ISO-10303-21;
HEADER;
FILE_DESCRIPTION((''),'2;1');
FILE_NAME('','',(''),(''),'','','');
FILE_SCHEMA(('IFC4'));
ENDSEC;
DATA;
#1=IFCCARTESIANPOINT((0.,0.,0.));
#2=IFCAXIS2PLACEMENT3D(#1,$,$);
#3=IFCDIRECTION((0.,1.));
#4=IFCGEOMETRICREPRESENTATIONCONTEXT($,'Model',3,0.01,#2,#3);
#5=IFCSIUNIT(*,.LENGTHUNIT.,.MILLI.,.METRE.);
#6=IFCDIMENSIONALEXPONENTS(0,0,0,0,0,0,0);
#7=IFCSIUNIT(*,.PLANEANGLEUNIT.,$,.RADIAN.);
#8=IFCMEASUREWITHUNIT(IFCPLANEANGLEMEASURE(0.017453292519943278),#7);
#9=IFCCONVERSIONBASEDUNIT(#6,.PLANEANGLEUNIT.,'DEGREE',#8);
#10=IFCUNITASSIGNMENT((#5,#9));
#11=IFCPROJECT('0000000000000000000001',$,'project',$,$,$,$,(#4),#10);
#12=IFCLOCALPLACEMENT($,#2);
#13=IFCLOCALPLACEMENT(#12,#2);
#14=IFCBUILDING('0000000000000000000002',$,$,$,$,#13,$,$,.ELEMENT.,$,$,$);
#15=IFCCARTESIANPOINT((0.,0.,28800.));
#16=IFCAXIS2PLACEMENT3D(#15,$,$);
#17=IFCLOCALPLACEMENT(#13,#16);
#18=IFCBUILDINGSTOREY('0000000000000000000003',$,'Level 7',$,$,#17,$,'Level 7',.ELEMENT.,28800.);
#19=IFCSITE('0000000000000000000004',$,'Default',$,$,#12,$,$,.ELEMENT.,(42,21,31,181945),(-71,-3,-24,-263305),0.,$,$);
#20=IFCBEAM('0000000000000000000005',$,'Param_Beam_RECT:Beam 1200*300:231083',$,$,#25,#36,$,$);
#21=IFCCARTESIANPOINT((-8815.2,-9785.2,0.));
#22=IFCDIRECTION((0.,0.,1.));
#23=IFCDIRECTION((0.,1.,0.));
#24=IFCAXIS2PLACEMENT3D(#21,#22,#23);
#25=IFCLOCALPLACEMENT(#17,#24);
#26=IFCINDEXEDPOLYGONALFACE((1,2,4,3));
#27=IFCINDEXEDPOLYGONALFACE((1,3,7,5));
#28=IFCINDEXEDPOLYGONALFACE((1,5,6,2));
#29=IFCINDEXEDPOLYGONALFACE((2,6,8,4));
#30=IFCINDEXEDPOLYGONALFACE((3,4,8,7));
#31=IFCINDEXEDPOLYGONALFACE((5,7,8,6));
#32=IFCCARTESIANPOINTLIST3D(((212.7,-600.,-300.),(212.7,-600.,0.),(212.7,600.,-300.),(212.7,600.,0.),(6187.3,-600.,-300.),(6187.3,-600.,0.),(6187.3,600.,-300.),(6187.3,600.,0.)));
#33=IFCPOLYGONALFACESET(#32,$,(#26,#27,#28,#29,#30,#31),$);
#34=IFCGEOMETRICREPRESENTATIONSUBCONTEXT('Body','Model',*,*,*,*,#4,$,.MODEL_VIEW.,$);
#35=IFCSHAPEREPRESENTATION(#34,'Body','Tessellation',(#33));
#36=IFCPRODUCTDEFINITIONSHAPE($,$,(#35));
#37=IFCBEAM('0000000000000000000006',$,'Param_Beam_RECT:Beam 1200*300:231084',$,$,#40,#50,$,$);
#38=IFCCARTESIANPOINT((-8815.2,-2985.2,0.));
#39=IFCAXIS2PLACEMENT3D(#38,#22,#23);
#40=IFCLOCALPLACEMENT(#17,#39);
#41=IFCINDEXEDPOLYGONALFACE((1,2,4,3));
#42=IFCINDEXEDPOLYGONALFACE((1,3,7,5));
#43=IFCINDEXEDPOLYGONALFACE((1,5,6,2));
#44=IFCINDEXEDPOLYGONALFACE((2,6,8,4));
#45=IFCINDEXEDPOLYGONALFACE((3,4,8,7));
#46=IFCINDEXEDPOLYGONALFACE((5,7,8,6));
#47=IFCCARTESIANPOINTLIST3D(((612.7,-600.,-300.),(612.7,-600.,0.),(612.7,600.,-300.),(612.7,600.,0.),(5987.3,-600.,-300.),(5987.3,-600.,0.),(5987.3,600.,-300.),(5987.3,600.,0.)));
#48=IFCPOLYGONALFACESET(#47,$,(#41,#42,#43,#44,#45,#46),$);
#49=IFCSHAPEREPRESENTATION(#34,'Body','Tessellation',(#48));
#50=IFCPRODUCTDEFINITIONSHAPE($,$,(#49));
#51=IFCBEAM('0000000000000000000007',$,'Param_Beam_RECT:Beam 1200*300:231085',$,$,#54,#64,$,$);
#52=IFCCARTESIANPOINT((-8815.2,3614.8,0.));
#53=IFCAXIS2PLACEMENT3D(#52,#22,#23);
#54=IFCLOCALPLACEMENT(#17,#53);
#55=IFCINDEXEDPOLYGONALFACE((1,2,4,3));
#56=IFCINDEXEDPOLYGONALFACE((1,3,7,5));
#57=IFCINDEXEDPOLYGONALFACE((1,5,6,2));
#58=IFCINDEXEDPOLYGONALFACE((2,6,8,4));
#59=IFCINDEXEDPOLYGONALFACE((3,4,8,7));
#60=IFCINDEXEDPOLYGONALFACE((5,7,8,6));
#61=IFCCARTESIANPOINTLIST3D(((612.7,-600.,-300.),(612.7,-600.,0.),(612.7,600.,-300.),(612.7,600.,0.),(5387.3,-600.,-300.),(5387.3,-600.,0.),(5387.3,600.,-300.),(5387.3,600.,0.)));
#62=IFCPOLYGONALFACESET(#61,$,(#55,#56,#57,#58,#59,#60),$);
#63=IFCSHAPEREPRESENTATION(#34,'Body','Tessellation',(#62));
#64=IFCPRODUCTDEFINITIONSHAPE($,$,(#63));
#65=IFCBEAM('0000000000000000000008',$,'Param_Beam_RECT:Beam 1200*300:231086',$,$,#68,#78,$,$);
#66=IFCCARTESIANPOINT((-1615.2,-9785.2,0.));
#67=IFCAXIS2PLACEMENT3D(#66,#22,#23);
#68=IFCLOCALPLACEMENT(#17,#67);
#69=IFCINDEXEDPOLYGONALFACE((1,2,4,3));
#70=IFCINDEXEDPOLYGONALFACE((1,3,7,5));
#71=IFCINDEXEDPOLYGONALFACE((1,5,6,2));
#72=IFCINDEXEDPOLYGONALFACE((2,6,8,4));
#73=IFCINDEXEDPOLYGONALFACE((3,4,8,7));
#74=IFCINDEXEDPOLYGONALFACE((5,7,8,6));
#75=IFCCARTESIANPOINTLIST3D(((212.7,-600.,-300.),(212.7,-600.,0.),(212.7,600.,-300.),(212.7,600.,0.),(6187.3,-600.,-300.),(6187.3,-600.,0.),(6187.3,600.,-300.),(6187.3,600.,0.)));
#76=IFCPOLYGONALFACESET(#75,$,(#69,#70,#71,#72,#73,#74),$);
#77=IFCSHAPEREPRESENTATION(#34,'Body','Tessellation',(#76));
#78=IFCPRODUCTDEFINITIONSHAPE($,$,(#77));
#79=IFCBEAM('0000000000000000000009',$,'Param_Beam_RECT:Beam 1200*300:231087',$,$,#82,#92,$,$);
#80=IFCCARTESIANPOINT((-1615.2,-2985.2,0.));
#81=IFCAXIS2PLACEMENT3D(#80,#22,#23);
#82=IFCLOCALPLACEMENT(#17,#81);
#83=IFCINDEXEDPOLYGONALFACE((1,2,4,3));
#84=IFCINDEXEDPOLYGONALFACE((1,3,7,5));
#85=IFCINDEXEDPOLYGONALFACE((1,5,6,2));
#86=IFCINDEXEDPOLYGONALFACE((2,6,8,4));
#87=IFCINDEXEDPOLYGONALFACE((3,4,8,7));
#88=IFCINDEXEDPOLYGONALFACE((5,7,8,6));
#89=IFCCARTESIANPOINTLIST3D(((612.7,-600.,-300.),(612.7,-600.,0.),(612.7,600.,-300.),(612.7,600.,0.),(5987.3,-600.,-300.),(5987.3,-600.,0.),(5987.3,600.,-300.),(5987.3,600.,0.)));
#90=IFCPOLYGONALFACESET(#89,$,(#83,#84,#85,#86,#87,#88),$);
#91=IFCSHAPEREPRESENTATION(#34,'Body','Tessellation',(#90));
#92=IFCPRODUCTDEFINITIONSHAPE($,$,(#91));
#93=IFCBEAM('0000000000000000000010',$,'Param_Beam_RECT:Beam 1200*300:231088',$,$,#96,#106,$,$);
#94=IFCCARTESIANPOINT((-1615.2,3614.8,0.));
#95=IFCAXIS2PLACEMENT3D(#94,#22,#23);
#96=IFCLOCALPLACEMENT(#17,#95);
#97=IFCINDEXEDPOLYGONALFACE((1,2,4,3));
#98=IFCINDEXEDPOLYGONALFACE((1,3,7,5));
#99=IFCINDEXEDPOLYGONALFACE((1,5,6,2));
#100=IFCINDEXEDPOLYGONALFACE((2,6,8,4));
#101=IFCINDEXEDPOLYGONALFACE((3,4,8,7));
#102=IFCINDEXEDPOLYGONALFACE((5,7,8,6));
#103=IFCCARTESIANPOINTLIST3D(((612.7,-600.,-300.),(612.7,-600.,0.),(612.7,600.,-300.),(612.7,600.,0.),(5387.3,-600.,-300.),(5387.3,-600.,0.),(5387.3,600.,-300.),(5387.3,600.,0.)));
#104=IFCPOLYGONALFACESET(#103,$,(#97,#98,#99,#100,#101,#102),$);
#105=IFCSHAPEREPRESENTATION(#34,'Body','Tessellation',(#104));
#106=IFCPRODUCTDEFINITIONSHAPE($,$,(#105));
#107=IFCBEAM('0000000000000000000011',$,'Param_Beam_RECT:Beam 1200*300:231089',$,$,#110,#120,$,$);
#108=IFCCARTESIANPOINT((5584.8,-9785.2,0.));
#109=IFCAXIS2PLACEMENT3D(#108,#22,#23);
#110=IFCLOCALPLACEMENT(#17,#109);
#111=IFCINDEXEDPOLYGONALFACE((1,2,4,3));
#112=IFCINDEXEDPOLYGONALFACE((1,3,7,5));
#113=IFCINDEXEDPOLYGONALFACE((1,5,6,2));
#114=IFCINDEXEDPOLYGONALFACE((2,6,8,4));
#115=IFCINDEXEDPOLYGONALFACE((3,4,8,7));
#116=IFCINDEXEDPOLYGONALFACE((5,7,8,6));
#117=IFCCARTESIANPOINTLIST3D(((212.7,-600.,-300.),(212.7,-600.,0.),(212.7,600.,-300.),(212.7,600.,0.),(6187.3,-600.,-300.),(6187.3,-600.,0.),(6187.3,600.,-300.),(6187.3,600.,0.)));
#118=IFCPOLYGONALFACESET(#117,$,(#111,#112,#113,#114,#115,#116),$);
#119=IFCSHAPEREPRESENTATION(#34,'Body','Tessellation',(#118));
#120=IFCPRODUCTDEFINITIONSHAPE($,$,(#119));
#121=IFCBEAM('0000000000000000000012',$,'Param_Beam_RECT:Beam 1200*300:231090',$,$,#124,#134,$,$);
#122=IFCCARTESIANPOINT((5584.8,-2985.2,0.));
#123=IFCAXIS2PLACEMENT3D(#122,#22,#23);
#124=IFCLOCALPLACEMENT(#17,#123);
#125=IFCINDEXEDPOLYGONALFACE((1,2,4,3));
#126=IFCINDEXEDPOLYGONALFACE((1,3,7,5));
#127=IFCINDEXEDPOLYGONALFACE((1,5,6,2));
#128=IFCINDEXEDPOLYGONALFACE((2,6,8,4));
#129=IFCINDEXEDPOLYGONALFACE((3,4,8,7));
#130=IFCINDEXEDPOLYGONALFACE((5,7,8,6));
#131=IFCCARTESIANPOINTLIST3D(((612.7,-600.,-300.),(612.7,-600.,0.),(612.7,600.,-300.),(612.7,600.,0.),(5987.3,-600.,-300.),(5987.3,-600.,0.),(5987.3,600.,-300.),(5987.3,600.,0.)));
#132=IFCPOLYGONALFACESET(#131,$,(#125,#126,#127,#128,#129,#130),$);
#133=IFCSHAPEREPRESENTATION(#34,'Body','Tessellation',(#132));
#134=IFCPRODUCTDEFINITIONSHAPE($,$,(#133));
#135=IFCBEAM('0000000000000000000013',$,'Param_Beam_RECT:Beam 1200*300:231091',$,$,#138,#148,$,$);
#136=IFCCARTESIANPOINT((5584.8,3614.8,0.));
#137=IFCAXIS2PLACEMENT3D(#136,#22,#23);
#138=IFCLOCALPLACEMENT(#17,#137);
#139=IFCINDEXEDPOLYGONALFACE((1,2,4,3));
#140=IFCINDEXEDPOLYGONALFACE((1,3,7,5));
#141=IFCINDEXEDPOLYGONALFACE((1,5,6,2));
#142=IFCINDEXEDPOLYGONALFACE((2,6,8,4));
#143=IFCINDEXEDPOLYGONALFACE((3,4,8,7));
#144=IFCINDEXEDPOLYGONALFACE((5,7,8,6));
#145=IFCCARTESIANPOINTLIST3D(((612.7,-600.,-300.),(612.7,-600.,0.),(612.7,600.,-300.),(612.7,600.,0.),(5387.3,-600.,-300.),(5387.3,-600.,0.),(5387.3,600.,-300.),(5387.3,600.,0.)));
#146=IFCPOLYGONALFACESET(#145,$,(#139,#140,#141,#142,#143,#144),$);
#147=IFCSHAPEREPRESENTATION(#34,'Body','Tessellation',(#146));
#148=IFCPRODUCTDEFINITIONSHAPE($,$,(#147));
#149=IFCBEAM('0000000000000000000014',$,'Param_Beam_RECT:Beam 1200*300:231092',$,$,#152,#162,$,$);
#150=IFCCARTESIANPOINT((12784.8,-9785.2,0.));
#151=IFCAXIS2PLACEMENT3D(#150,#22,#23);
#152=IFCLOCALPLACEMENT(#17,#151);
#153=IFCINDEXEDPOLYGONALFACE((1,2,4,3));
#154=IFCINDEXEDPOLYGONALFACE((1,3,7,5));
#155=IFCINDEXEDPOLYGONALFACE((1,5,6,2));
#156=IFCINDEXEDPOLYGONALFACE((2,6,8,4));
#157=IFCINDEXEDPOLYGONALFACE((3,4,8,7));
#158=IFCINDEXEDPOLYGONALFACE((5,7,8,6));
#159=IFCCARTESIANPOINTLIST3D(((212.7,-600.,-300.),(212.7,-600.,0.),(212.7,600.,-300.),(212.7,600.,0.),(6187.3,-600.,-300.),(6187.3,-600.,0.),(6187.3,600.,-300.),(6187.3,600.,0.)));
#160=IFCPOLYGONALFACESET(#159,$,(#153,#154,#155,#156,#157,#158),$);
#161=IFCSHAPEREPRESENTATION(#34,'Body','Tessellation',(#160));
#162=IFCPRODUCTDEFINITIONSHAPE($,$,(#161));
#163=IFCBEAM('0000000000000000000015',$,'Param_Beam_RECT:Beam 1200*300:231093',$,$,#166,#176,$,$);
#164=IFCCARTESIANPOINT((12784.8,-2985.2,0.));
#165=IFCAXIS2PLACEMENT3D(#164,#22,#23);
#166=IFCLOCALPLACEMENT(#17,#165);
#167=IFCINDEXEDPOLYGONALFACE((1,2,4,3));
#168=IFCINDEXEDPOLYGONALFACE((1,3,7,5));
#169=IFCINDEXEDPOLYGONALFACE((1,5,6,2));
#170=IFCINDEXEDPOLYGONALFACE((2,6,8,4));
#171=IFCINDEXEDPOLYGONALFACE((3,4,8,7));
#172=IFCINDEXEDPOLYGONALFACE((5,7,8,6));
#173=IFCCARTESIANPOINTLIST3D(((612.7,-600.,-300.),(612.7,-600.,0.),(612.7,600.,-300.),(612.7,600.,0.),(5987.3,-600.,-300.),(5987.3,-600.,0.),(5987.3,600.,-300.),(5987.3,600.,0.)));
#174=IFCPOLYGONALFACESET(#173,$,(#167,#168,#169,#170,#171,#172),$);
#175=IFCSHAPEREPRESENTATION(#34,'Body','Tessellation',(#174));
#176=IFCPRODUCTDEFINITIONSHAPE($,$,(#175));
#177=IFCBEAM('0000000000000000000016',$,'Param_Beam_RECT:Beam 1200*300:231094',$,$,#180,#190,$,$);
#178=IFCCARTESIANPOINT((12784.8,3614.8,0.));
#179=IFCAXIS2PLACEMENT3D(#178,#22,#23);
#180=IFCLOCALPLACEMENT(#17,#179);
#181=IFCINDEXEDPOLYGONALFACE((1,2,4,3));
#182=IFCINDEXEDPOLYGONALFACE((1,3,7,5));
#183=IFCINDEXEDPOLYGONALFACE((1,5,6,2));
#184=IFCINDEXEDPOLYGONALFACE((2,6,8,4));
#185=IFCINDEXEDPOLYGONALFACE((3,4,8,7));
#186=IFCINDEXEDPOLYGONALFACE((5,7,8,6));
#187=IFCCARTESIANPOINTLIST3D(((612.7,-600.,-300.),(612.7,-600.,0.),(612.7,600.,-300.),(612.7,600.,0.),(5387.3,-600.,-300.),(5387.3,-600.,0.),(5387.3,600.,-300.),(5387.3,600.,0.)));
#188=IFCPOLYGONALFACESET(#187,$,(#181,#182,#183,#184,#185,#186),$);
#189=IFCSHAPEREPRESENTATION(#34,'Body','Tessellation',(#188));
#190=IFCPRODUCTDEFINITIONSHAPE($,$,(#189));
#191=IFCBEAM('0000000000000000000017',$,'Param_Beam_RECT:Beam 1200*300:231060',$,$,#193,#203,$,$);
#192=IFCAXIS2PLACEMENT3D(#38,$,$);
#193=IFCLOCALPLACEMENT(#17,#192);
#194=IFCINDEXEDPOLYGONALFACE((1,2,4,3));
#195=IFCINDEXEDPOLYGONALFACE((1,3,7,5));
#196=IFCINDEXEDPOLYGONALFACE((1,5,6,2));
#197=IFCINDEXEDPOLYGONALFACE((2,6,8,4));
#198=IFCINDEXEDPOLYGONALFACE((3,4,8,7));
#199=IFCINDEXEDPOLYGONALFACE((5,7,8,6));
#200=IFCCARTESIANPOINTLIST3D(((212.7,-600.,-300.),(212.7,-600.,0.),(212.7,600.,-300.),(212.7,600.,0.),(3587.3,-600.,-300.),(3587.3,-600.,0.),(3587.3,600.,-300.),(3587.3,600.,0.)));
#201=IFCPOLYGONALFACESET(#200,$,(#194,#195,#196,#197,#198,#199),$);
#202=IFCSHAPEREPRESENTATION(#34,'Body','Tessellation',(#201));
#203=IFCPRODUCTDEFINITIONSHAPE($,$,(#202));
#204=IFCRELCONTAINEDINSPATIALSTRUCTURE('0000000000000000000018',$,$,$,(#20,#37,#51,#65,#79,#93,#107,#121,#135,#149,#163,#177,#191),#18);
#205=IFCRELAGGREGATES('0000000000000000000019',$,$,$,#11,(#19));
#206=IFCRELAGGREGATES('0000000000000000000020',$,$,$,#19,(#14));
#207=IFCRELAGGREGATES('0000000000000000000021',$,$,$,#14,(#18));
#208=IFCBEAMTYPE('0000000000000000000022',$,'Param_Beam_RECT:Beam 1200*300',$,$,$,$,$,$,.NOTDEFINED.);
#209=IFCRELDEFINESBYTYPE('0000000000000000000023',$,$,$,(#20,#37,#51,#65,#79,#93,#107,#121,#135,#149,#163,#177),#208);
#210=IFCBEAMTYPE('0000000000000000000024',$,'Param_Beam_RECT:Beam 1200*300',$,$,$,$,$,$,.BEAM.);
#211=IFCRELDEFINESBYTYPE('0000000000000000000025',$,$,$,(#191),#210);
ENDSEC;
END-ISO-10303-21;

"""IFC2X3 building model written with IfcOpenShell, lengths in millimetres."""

from ifc_helpers import new_model, entity, si_unit, converted_unit, direction, frame, frame_2d, origin, origin_2d_with_axis, place, context, subcontext, project, spatial, rectangle, extrude, type_object, element, save


model = new_model("IFC2X3")

# Units and contexts
model_context = context("Model", 3, precision=0.01, world=origin(), true_north=direction((0.0, 1.0)))
body_context = subcontext(model_context, "Body", "Model", "MODEL_VIEW")
ifc_project = project(units=[si_unit("LENGTHUNIT", "METRE", prefix="MILLI"), converted_unit("PLANEANGLEUNIT", "DEGREE", entity("IfcPlaneAngleMeasure", 0.017453292519943278), si_unit("PLANEANGLEUNIT", "RADIAN"), dimensions=[0, 0, 0, 0, 0, 0, 0])], contexts=[model_context])

# Site, building, storey
site_placement = place(None, origin())
site = spatial("IfcSite", under=ifc_project, at=site_placement, Name="Default", CompositionType="ELEMENT", RefLatitude=(42, 21, 31, 181945), RefLongitude=(-71, -3, -24, -263305), RefElevation=0.0)
building_placement = place(site_placement, origin())
building = spatial("IfcBuilding", under=site, at=building_placement, CompositionType="ELEMENT")
storey_placement = place(building_placement, frame((0.0, 0.0, 28800.0)))
storey = spatial("IfcBuildingStorey", under=building, at=storey_placement, Name="Level 7", LongName="Level 7", CompositionType="ELEMENT", Elevation=28800.0)

# Beams
beam_type_1 = type_object("IfcBeamType", Name="Param_Beam_RECT:Beam 1200*300", PredefinedType="NOTDEFINED")
beam_1_placement = place(storey_placement, frame((-8815.2, -9785.2, 0.0), z_axis=(0.0, 0.0, 1.0), x_axis=(0.0, 1.0, 0.0)))
element("IfcBeam", 1, at=beam_1_placement, inside=storey, type_object=beam_type_1, Name="Param_Beam_RECT:Beam 1200*300:231083", context=body_context, shape_type="SweptSolid", body=[
    extrude(rectangle(XDim=300.0, YDim=1200.0, at=frame_2d((0.0, 0.0), x_axis=(1.0, 0.0))), frame((212.7, 0.0, -150.0), z_axis=(1.0, 0.0, 0.0), x_axis=(0.0, 0.0, -1.0)), (0.0, 0.0, 1.0), 5974.6),
])
beam_2_placement = place(storey_placement, frame((-8815.2, -2985.2, 0.0), z_axis=(0.0, 0.0, 1.0), x_axis=(0.0, 1.0, 0.0)))
element("IfcBeam", 2, at=beam_2_placement, inside=storey, type_object=beam_type_1, Name="Param_Beam_RECT:Beam 1200*300:231084", context=body_context, shape_type="SweptSolid", body=[
    extrude(rectangle(XDim=300.0, YDim=1200.0, at=frame_2d((0.0, 0.0), x_axis=(1.0, 0.0))), frame((612.7, 0.0, -150.0), z_axis=(1.0, 0.0, 0.0), x_axis=(0.0, 0.0, -1.0)), (0.0, 0.0, 1.0), 5374.6),
])
beam_3_placement = place(storey_placement, frame((-8815.2, 3614.8, 0.0), z_axis=(0.0, 0.0, 1.0), x_axis=(0.0, 1.0, 0.0)))
element("IfcBeam", 3, at=beam_3_placement, inside=storey, type_object=beam_type_1, Name="Param_Beam_RECT:Beam 1200*300:231085", context=body_context, shape_type="SweptSolid", body=[
    extrude(rectangle(XDim=300.0, YDim=1200.0, at=frame_2d((0.0, 0.0), x_axis=(1.0, 0.0))), frame((612.7, 0.0, -150.0), z_axis=(1.0, 0.0, 0.0), x_axis=(0.0, 0.0, -1.0)), (0.0, 0.0, 1.0), 4774.6),
])
beam_4_placement = place(storey_placement, frame((-1615.2, -9785.2, 0.0), z_axis=(0.0, 0.0, 1.0), x_axis=(0.0, 1.0, 0.0)))
element("IfcBeam", 4, at=beam_4_placement, inside=storey, type_object=beam_type_1, Name="Param_Beam_RECT:Beam 1200*300:231086", context=body_context, shape_type="SweptSolid", body=[
    extrude(rectangle(XDim=300.0, YDim=1200.0, at=frame_2d((0.0, 0.0), x_axis=(1.0, 0.0))), frame((212.7, 0.0, -150.0), z_axis=(1.0, 0.0, 0.0), x_axis=(0.0, 0.0, -1.0)), (0.0, 0.0, 1.0), 5974.6),
])
beam_5_placement = place(storey_placement, frame((-1615.2, -2985.2, 0.0), z_axis=(0.0, 0.0, 1.0), x_axis=(0.0, 1.0, 0.0)))
element("IfcBeam", 5, at=beam_5_placement, inside=storey, type_object=beam_type_1, Name="Param_Beam_RECT:Beam 1200*300:231087", context=body_context, shape_type="SweptSolid", body=[
    extrude(rectangle(XDim=300.0, YDim=1200.0, at=frame_2d((0.0, 0.0), x_axis=(1.0, 0.0))), frame((612.7, 0.0, -150.0), z_axis=(1.0, 0.0, 0.0), x_axis=(0.0, 0.0, -1.0)), (0.0, 0.0, 1.0), 5374.6),
])
beam_6_placement = place(storey_placement, frame((-1615.2, 3614.8, 0.0), z_axis=(0.0, 0.0, 1.0), x_axis=(0.0, 1.0, 0.0)))
element("IfcBeam", 6, at=beam_6_placement, inside=storey, type_object=beam_type_1, Name="Param_Beam_RECT:Beam 1200*300:231088", context=body_context, shape_type="SweptSolid", body=[
    extrude(rectangle(XDim=300.0, YDim=1200.0, at=frame_2d((0.0, 0.0), x_axis=(1.0, 0.0))), frame((612.7, 0.0, -150.0), z_axis=(1.0, 0.0, 0.0), x_axis=(0.0, 0.0, -1.0)), (0.0, 0.0, 1.0), 4774.6),
])
beam_7_placement = place(storey_placement, frame((5584.8, -9785.2, 0.0), z_axis=(0.0, 0.0, 1.0), x_axis=(0.0, 1.0, 0.0)))
element("IfcBeam", 7, at=beam_7_placement, inside=storey, type_object=beam_type_1, Name="Param_Beam_RECT:Beam 1200*300:231089", context=body_context, shape_type="SweptSolid", body=[
    extrude(rectangle(XDim=300.0, YDim=1200.0, at=frame_2d((0.0, 0.0), x_axis=(1.0, 0.0))), frame((212.7, 0.0, -150.0), z_axis=(1.0, 0.0, 0.0), x_axis=(0.0, 0.0, -1.0)), (0.0, 0.0, 1.0), 5974.6),
])
beam_8_placement = place(storey_placement, frame((5584.8, -2985.2, 0.0), z_axis=(0.0, 0.0, 1.0), x_axis=(0.0, 1.0, 0.0)))
element("IfcBeam", 8, at=beam_8_placement, inside=storey, type_object=beam_type_1, Name="Param_Beam_RECT:Beam 1200*300:231090", context=body_context, shape_type="SweptSolid", body=[
    extrude(rectangle(XDim=300.0, YDim=1200.0, at=frame_2d((0.0, 0.0), x_axis=(1.0, 0.0))), frame((612.7, 0.0, -150.0), z_axis=(1.0, 0.0, 0.0), x_axis=(0.0, 0.0, -1.0)), (0.0, 0.0, 1.0), 5374.6),
])
beam_9_placement = place(storey_placement, frame((5584.8, 3614.8, 0.0), z_axis=(0.0, 0.0, 1.0), x_axis=(0.0, 1.0, 0.0)))
element("IfcBeam", 9, at=beam_9_placement, inside=storey, type_object=beam_type_1, Name="Param_Beam_RECT:Beam 1200*300:231091", context=body_context, shape_type="SweptSolid", body=[
    extrude(rectangle(XDim=300.0, YDim=1200.0, at=frame_2d((0.0, 0.0), x_axis=(1.0, 0.0))), frame((612.7, 0.0, -150.0), z_axis=(1.0, 0.0, 0.0), x_axis=(0.0, 0.0, -1.0)), (0.0, 0.0, 1.0), 4774.6),
])
beam_10_placement = place(storey_placement, frame((12784.8, -9785.2, 0.0), z_axis=(0.0, 0.0, 1.0), x_axis=(0.0, 1.0, 0.0)))
element("IfcBeam", 10, at=beam_10_placement, inside=storey, type_object=beam_type_1, Name="Param_Beam_RECT:Beam 1200*300:231092", context=body_context, shape_type="SweptSolid", body=[
    extrude(rectangle(XDim=300.0, YDim=1200.0, at=origin_2d_with_axis()), frame((212.7, 0.0, -150.0), z_axis=(1.0, 0.0, 0.0), x_axis=(0.0, 0.0, -1.0)), (0.0, 0.0, 1.0), 5974.6),
])
beam_11_placement = place(storey_placement, frame((12784.8, -2985.2, 0.0), z_axis=(0.0, 0.0, 1.0), x_axis=(0.0, 1.0, 0.0)))
element("IfcBeam", 11, at=beam_11_placement, inside=storey, type_object=beam_type_1, Name="Param_Beam_RECT:Beam 1200*300:231093", context=body_context, shape_type="SweptSolid", body=[
    extrude(rectangle(XDim=300.0, YDim=1200.0, at=frame_2d((0.0, 0.0), x_axis=(1.0, 0.0))), frame((612.7, 0.0, -150.0), z_axis=(1.0, 0.0, 0.0), x_axis=(0.0, 0.0, -1.0)), (0.0, 0.0, 1.0), 5374.6),
])
beam_12_placement = place(storey_placement, frame((12784.8, 3614.8, 0.0), z_axis=(0.0, 0.0, 1.0), x_axis=(0.0, 1.0, 0.0)))
element("IfcBeam", 12, at=beam_12_placement, inside=storey, type_object=beam_type_1, Name="Param_Beam_RECT:Beam 1200*300:231094", context=body_context, shape_type="SweptSolid", body=[
    extrude(rectangle(XDim=300.0, YDim=1200.0, at=origin_2d_with_axis()), frame((612.7, 0.0, -150.0), z_axis=(1.0, 0.0, 0.0), x_axis=(0.0, 0.0, -1.0)), (0.0, 0.0, 1.0), 4774.6),
])
beam_type_2 = type_object("IfcBeamType", Name="Param_Beam_RECT:Beam 1200*300", PredefinedType="BEAM")
beam_13_placement = place(storey_placement, frame((-8815.2, -2985.2, 0.0)))
element("IfcBeam", 13, at=beam_13_placement, inside=storey, type_object=beam_type_2, Name="Param_Beam_RECT:Beam 1200*300:231060", context=body_context, shape_type="SweptSolid", body=[
    extrude(rectangle(XDim=300.0, YDim=1200.0, at=frame_2d((0.0, 0.0), x_axis=(1.0, 0.0))), frame((212.7, 0.0, -150.0), z_axis=(1.0, 0.0, 0.0), x_axis=(0.0, 0.0, -1.0)), (0.0, 0.0, 1.0), 3374.6),
])

save(model, "model.ifc")
